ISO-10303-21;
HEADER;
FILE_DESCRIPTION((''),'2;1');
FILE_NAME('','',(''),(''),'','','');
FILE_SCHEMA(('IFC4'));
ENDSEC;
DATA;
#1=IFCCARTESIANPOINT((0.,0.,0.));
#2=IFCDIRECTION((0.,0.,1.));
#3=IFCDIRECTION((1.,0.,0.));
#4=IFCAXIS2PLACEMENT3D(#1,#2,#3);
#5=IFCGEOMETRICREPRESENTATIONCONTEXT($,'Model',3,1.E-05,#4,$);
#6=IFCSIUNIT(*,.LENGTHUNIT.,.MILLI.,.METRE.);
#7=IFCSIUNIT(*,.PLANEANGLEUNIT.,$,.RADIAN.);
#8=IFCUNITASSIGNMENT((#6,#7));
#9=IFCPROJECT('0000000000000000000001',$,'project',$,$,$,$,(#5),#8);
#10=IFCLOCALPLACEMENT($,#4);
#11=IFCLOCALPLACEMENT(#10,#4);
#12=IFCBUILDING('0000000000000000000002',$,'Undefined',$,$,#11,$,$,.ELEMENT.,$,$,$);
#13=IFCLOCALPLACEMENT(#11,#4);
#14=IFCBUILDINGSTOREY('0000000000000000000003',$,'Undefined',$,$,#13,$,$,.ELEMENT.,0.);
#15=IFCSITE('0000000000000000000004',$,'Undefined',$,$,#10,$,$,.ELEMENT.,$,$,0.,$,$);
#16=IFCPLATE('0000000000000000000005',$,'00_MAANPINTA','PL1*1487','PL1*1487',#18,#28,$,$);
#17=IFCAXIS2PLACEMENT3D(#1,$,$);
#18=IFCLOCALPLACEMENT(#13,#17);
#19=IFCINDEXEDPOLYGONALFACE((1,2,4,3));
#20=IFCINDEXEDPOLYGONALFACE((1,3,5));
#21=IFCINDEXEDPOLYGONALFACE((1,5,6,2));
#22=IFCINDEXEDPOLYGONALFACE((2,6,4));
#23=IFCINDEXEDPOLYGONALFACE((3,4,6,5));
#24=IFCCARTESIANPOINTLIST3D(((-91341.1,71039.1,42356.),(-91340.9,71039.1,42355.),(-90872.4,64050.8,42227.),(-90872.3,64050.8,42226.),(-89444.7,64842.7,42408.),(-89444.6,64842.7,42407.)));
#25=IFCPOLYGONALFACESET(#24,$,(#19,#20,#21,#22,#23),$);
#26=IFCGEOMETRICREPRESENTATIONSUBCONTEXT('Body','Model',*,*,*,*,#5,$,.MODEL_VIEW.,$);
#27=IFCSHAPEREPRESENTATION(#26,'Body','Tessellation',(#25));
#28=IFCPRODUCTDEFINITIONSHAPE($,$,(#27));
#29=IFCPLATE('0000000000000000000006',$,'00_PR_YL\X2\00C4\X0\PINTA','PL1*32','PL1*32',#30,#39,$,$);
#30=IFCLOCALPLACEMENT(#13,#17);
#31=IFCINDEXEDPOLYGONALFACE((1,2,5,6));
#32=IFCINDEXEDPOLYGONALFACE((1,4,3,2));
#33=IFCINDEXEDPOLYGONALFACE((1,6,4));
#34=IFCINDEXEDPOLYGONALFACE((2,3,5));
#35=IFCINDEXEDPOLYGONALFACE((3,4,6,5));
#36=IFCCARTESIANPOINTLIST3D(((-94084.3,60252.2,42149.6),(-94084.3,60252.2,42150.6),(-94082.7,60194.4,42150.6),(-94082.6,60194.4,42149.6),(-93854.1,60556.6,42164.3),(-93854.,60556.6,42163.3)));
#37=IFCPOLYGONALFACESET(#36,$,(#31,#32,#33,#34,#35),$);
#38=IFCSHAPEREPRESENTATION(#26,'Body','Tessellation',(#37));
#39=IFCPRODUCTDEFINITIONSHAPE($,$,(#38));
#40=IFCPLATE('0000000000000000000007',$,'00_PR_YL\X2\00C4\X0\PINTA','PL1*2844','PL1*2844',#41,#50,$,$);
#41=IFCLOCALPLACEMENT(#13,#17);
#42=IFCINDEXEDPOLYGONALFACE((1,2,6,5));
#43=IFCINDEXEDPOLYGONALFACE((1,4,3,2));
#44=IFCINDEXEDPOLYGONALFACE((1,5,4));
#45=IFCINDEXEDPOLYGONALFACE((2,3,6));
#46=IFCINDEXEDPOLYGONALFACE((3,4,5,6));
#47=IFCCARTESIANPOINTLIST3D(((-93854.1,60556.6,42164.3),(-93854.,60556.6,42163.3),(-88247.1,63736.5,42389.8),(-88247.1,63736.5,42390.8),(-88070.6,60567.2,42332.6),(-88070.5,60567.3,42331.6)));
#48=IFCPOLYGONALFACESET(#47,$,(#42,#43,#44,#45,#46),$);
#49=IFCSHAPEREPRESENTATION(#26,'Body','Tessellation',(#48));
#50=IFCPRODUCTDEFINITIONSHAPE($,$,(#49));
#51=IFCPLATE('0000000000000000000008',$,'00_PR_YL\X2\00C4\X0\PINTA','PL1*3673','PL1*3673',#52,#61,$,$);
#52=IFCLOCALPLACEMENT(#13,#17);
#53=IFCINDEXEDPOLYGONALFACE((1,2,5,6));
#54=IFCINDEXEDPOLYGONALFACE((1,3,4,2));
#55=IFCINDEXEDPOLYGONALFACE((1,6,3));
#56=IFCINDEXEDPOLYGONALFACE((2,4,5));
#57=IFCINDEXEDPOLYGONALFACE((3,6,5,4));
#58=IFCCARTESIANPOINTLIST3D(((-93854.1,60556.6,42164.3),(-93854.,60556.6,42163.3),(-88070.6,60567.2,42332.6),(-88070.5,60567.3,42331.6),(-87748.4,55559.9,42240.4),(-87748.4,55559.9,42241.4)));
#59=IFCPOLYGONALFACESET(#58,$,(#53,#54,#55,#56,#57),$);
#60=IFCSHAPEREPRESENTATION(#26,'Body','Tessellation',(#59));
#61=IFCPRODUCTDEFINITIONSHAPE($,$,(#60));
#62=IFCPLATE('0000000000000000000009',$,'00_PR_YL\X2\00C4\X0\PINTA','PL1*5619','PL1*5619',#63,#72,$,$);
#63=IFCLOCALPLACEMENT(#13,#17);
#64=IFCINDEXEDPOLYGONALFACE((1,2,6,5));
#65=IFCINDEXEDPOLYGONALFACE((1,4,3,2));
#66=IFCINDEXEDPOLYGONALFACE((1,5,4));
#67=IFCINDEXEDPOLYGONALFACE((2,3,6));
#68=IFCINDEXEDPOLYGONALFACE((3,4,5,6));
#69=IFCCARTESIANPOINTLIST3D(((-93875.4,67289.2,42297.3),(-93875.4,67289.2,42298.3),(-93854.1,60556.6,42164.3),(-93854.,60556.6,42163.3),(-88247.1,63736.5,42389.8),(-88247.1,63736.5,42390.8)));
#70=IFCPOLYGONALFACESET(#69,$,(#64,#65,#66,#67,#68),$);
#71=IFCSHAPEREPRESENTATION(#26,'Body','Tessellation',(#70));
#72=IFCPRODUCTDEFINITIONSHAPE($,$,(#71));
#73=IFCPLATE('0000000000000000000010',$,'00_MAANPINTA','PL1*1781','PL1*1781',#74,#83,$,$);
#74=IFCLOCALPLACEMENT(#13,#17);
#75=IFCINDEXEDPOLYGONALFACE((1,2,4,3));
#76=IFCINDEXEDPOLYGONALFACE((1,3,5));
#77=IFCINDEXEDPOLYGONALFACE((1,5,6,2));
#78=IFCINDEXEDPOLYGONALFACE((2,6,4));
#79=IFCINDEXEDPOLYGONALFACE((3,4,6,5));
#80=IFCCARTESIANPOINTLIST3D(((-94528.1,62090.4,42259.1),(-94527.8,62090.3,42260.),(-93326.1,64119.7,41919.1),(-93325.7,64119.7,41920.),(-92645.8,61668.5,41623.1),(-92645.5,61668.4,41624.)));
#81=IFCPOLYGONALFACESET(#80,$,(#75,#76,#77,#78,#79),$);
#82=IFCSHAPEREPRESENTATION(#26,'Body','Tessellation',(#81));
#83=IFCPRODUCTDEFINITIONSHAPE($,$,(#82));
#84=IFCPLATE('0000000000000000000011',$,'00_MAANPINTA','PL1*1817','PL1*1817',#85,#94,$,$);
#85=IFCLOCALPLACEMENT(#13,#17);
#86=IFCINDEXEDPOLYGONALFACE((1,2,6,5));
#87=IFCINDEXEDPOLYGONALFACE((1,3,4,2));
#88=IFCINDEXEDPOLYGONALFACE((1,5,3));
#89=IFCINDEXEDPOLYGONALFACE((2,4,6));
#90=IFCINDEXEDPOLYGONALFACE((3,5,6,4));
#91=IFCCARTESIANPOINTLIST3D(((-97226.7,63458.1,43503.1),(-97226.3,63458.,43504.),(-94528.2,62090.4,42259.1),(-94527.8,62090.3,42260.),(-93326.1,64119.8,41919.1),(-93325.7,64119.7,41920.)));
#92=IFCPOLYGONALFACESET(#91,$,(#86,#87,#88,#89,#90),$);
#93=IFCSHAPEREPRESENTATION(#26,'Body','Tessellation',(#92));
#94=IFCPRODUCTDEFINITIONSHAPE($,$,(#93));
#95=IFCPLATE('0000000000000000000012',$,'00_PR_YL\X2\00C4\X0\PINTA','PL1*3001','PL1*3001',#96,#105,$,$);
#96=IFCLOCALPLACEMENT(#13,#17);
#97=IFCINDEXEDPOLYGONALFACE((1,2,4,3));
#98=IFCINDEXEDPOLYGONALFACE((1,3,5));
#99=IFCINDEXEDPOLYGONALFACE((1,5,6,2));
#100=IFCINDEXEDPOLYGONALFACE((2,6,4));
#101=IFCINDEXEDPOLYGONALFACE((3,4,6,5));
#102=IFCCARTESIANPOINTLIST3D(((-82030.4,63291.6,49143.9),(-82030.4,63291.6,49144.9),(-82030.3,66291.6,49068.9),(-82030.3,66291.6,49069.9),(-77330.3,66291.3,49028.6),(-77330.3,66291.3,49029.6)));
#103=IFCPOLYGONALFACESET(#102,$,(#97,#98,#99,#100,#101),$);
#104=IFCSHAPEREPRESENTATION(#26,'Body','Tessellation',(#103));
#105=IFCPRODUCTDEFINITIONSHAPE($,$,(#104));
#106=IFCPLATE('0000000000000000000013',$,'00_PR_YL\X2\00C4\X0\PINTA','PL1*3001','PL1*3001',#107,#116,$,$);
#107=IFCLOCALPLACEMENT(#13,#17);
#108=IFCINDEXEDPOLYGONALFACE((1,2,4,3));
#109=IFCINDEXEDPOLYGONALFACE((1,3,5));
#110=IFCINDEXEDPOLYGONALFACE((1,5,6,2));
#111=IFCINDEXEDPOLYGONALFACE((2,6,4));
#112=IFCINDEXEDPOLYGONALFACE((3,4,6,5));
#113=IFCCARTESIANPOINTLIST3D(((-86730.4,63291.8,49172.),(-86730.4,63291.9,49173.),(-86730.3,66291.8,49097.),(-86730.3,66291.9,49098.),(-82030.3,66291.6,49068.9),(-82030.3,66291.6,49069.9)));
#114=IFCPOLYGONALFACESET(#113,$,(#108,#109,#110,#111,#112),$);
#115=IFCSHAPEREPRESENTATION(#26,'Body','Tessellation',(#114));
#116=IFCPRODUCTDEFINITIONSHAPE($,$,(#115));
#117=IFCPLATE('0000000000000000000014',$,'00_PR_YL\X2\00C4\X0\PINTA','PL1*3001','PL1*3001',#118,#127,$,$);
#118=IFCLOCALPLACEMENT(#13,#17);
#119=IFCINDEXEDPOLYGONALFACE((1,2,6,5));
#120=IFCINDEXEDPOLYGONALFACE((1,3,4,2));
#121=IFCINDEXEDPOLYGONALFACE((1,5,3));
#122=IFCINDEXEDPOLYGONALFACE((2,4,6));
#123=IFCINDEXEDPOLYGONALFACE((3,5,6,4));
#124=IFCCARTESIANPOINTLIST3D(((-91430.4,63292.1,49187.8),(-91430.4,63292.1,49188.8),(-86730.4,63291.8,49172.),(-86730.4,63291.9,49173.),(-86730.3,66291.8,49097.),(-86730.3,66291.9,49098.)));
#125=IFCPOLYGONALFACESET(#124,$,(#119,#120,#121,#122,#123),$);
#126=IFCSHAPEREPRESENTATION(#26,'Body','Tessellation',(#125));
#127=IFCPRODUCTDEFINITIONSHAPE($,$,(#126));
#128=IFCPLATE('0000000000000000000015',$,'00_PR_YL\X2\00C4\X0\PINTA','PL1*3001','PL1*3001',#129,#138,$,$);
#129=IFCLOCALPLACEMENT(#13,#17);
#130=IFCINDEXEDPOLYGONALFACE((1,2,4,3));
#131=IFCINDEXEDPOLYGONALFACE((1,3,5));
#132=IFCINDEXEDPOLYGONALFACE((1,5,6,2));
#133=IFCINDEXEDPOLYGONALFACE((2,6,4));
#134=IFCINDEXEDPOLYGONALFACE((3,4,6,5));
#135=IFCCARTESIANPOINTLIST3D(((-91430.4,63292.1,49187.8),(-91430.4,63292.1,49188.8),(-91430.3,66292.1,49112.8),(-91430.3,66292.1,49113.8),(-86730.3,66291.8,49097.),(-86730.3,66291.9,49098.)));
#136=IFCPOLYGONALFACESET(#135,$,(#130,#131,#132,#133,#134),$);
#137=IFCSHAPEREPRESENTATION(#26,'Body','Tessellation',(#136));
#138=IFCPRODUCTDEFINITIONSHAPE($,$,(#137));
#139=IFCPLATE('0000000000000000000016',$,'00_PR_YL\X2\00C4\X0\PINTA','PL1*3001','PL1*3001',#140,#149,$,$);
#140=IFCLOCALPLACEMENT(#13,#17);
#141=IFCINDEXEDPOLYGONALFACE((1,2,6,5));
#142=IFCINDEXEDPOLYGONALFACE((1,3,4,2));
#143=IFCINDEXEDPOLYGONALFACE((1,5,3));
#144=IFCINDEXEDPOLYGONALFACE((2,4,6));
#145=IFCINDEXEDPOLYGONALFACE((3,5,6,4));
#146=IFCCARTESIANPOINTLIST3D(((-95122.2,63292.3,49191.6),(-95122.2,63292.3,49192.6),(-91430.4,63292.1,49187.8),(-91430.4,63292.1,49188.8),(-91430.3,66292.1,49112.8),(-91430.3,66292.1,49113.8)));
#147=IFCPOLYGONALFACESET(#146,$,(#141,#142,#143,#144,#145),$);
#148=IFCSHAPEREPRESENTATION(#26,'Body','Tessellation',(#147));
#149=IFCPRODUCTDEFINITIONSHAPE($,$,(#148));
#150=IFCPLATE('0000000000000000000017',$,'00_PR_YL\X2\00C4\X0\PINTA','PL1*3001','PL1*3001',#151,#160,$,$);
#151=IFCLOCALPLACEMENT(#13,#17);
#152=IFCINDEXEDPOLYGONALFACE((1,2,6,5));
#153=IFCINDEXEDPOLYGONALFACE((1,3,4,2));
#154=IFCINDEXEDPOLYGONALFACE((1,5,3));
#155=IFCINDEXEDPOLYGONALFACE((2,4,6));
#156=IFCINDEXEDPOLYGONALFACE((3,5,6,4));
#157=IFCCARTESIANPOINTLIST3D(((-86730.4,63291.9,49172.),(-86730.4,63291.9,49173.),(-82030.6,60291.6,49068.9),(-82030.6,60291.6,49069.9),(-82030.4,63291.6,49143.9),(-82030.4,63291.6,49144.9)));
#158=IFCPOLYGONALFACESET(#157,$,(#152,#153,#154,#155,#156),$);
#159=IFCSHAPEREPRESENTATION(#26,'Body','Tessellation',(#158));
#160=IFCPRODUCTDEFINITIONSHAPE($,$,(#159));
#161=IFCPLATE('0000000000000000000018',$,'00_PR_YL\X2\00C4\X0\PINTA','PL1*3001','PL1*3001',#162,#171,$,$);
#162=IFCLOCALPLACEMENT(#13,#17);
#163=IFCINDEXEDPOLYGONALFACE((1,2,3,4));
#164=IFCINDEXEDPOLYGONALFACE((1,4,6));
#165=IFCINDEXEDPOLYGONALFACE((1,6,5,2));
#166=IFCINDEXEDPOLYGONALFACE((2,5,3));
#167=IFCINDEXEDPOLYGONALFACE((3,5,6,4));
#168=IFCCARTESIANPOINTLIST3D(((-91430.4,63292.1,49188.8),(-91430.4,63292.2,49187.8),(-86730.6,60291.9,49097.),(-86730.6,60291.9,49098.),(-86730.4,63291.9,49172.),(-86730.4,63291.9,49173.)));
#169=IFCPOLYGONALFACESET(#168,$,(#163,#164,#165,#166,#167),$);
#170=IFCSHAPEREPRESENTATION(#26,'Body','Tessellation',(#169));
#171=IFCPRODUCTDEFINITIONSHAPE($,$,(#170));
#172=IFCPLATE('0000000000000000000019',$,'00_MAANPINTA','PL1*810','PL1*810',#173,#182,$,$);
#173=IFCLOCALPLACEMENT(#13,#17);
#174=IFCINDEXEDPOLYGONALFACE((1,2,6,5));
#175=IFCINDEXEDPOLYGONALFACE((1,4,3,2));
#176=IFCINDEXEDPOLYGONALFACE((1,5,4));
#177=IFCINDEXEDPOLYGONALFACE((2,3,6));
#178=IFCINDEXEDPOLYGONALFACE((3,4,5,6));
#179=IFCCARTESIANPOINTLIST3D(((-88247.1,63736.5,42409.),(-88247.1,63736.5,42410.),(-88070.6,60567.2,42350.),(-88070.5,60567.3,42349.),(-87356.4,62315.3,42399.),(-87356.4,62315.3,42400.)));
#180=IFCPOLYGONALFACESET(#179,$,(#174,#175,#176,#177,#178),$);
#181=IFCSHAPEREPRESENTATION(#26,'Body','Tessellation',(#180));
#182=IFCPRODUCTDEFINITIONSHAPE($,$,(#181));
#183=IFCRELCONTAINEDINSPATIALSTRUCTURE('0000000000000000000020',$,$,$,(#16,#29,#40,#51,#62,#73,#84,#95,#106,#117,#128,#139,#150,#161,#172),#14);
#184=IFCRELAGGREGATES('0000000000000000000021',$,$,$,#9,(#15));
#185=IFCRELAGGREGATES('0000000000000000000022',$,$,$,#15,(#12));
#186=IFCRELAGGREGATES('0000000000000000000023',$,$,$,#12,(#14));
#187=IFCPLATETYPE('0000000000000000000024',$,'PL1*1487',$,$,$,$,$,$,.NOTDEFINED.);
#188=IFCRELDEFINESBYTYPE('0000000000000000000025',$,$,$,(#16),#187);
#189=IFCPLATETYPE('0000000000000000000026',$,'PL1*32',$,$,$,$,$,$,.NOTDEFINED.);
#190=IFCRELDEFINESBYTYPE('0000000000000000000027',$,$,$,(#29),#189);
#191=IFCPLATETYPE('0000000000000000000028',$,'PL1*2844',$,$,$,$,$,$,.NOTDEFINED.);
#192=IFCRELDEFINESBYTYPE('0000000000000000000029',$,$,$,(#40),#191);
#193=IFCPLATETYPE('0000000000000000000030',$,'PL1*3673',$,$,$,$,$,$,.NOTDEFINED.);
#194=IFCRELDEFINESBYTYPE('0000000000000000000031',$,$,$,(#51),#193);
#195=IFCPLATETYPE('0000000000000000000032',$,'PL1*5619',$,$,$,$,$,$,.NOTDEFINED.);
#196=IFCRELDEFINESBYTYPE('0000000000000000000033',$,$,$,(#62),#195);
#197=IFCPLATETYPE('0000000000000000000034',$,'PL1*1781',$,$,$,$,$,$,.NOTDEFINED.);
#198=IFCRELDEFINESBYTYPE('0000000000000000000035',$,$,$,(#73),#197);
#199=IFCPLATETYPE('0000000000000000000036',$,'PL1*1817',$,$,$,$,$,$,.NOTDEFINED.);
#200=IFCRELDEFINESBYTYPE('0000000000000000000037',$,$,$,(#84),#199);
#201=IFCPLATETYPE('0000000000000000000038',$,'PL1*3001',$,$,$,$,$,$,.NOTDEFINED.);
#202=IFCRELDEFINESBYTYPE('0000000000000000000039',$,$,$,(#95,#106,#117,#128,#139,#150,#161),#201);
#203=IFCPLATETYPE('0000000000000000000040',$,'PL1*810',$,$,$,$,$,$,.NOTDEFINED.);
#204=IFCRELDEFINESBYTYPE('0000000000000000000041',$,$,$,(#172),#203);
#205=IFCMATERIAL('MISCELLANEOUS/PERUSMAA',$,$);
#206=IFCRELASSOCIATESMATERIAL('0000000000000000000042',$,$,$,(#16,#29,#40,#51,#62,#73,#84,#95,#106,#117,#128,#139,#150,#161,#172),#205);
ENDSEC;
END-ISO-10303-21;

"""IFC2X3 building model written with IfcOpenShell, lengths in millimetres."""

from ifc_helpers import new_model, si_unit, frame, origin_with_axes, place, context, subcontext, project, spatial, polyline, outline, extrude, material, type_object, element, save


model = new_model("IFC2X3")

# Units and contexts
model_context = context("Model", 3, precision=1e-05, world=origin_with_axes())
body_context = subcontext(model_context, "Body", "Model", "MODEL_VIEW")
ifc_project = project(units=[si_unit("LENGTHUNIT", "METRE", prefix="MILLI"), si_unit("PLANEANGLEUNIT", "RADIAN")], contexts=[model_context])

# Site, building, storey
site_placement = place(None, origin_with_axes())
site = spatial("IfcSite", under=ifc_project, at=site_placement, Name="Undefined", CompositionType="ELEMENT", RefElevation=0.0)
building_placement = place(site_placement, origin_with_axes())
building = spatial("IfcBuilding", under=site, at=building_placement, Name="Undefined", CompositionType="ELEMENT")
storey_placement = place(building_placement, origin_with_axes())
storey = spatial("IfcBuildingStorey", under=building, at=storey_placement, Name="Undefined", CompositionType="ELEMENT", Elevation=0.0)

# Plates
ifc_material = material(Name="MISCELLANEOUS/PERUSMAA")
plate_type_1 = type_object("IfcPlateType", Name="PL1*1487", PredefinedType="NOTDEFINED")
plate_1_placement = place(storey_placement, frame((-89444.6, 64842.7, 42407.5), z_axis=(0.111618, 0.025824, -0.993416), x_axis=(-0.869161, -0.482098, -0.110189)))
element("IfcPlate", 1, at=plate_1_placement, inside=storey, type_object=plate_type_1, material=ifc_material, Name="00_MAANPINTA", Description="PL1*1487", ObjectType="PL1*1487", context=body_context, shape_type="SweptSolid", body=[
    extrude(outline(polyline([(0.0, 0.0), (1642.6, 0.0), (-1333.2, 6341.6), (0.0, 0.0)])), frame((0.0, 0.0, -0.5), z_axis=(0.0, 0.0, 1.0), x_axis=(1.0, 0.0, 0.0)), (0.0, 0.0, 1.0), 1.0),
])
plate_type_2 = type_object("IfcPlateType", Name="PL1*32", PredefinedType="NOTDEFINED")
plate_2_placement = place(storey_placement, frame((-93854.0, 60556.6, 42163.8), z_axis=(0.057025, 0.001812, -0.998371), x_axis=(-0.53355, -0.845163, -0.03201)))
element("IfcPlate", 2, at=plate_2_placement, inside=storey, type_object=plate_type_2, material=ifc_material, Name="00_PR_YLÄPINTA", Description="PL1*32", ObjectType="PL1*32", context=body_context, shape_type="SweptSolid", body=[
    extrude(outline(polyline([(0.0, 0.0), (428.5, 0.0), (380.5, 32.3), (0.0, 0.0)])), frame((0.0, 0.0, -0.5), z_axis=(0.0, 0.0, 1.0), x_axis=(1.0, 0.0, 0.0)), (0.0, 0.0, 1.0), 1.0),
])
plate_type_3 = type_object("IfcPlateType", Name="PL1*2844", PredefinedType="NOTDEFINED")
plate_3_placement = place(storey_placement, frame((-88247.1, 63736.5, 42390.3), z_axis=(0.029042, 0.019957, -0.999379), x_axis=(0.055609, -0.998285, -0.018319)))
element("IfcPlate", 3, at=plate_3_placement, inside=storey, type_object=plate_type_3, material=ifc_material, Name="00_PR_YLÄPINTA", Description="PL1*2844", ObjectType="PL1*2844", context=body_context, shape_type="SweptSolid", body=[
    extrude(outline(polyline([(0.0, 0.0), (3174.7, 0.0), (2866.8, 5777.7), (0.0, 0.0)])), frame((0.0, 0.0, -0.5), z_axis=(0.0, 0.0, 1.0), x_axis=(1.0, 0.0, 0.0)), (0.0, 0.0, 1.0), 1.0),
])
plate_type_4 = type_object("IfcPlateType", Name="PL1*3673", PredefinedType="NOTDEFINED")
plate_4_placement = place(storey_placement, frame((-88070.6, 60567.2, 42332.1), z_axis=(0.029042, 0.020064, -0.999377), x_axis=(0.0642, -0.997772, -0.018166)))
element("IfcPlate", 4, at=plate_4_placement, inside=storey, type_object=plate_type_4, material=ifc_material, Name="00_PR_YLÄPINTA", Description="PL1*3673", ObjectType="PL1*3673", context=body_context, shape_type="SweptSolid", body=[
    extrude(outline(polyline([(0.0, 0.0), (5018.5, 0.0), (-357.6, 5774.9), (0.0, 0.0)])), frame((0.0, 0.0, -0.5), z_axis=(0.0, 0.0, 1.0), x_axis=(1.0, 0.0, 0.0)), (0.0, 0.0, 1.0), 1.0),
])
plate_type_5 = type_object("IfcPlateType", Name="PL1*5619", PredefinedType="NOTDEFINED")
plate_5_placement = place(storey_placement, frame((-93854.0, 60556.6, 42163.8), z_axis=(0.029031, 0.019976, -0.999379), x_axis=(-0.003169, 0.999797, 0.019892)))
element("IfcPlate", 5, at=plate_5_placement, inside=storey, type_object=plate_type_5, material=ifc_material, Name="00_PR_YLÄPINTA", Description="PL1*5619", ObjectType="PL1*5619", context=body_context, shape_type="SweptSolid", body=[
    extrude(outline(polyline([(0.0, 0.0), (6733.9, 0.0), (3166.0, 5619.4), (0.0, 0.0)])), frame((0.0, 0.0, -0.5), z_axis=(0.0, 0.0, 1.0), x_axis=(1.0, 0.0, 0.0)), (0.0, 0.0, 1.0), 1.0),
])
plate_type_6 = type_object("IfcPlateType", Name="PL1*1781", PredefinedType="NOTDEFINED")
plate_6_placement = place(storey_placement, frame((-92645.7, 61668.4, 41623.5), z_axis=(-0.314481, 0.027309, -0.948871), x_axis=(-0.92672, 0.20772, 0.313118)))
element("IfcPlate", 6, at=plate_6_placement, inside=storey, type_object=plate_type_6, material=ifc_material, Name="00_MAANPINTA", Description="PL1*1781", ObjectType="PL1*1781", context=body_context, shape_type="SweptSolid", body=[
    extrude(outline(polyline([(0.0, 0.0), (2031.2, 0.0), (1232.3, 2245.1), (0.0, 0.0)])), frame((0.0, 0.0, -0.5), z_axis=(0.0, 0.0, 1.0), x_axis=(1.0, 0.0, 0.0)), (0.0, 0.0, 1.0), 1.0),
])
plate_type_7 = type_object("IfcPlateType", Name="PL1*1817", PredefinedType="NOTDEFINED")
plate_7_placement = place(storey_placement, frame((-93325.9, 64119.7, 41919.5), z_axis=(-0.386048, 0.074631, -0.919455), x_axis=(-0.504437, -0.851579, 0.142675)))
element("IfcPlate", 7, at=plate_7_placement, inside=storey, type_object=plate_type_7, material=ifc_material, Name="00_MAANPINTA", Description="PL1*1817", ObjectType="PL1*1817", context=body_context, shape_type="SweptSolid", body=[
    extrude(outline(polyline([(0.0, 0.0), (2383.0, 0.0), (2757.0, 3249.6), (0.0, 0.0)])), frame((0.0, 0.0, -0.5), z_axis=(0.0, 0.0, 1.0), x_axis=(1.0, 0.0, 0.0)), (0.0, 0.0, 1.0), 1.0),
])
plate_type_8 = type_object("IfcPlateType", Name="PL1*3001", PredefinedType="NOTDEFINED")
plate_8_placement = place(storey_placement, frame((-82030.4, 63291.6, 49144.4), z_axis=(-0.008578, -0.024991, -0.999651), x_axis=(0.000057, 0.999688, -0.024992)))
element("IfcPlate", 8, at=plate_8_placement, inside=storey, type_object=plate_type_8, material=ifc_material, Name="00_PR_YLÄPINTA", Description="PL1*3001", ObjectType="PL1*3001", context=body_context, shape_type="SweptSolid", body=[
    extrude(outline(polyline([(0.0, 0.0), (3000.9, 0.0), (3001.9, 4700.2), (0.0, 0.0)])), frame((0.0, 0.0, -0.5), z_axis=(0.0, 0.0, 1.0), x_axis=(1.0, 0.0, 0.0)), (0.0, 0.0, 1.0), 1.0),
])
plate_9_placement = place(storey_placement, frame((-86730.4, 63291.8, 49172.5), z_axis=(-0.005967, -0.024991, -0.99967), x_axis=(0.000057, 0.999688, -0.024992)))
element("IfcPlate", 9, at=plate_9_placement, inside=storey, type_object=plate_type_8, material=ifc_material, Name="00_PR_YLÄPINTA", Description="PL1*3001", ObjectType="PL1*3001", context=body_context, shape_type="SweptSolid", body=[
    extrude(outline(polyline([(0.0, 0.0), (3000.9, 0.0), (3001.6, 4700.1), (0.0, 0.0)])), frame((0.0, 0.0, -0.5), z_axis=(0.0, 0.0, 1.0), x_axis=(1.0, 0.0, 0.0)), (0.0, 0.0, 1.0), 1.0),
])
for number, where, z_axis, x_axis, name in (
    (10, (-86730.3, 66291.8, 49097.5), (-0.003357, -0.024992, -0.999682), (-0.000057, -0.999688, 0.024992), "00_PR_YLÄPINTA"),
    (11, (-91430.4, 63292.1, 49188.3), (-0.003357, -0.024992, -0.999682), (0.000057, 0.999688, -0.024992), "00_PR_YLÄPINTA"),
):
    element("IfcPlate", number, at=place(storey_placement, frame(where, z_axis=z_axis, x_axis=x_axis)), inside=storey, type_object=plate_type_8, material=ifc_material, Name=name, Description="PL1*3001", ObjectType="PL1*3001", context=body_context, shape_type="SweptSolid", body=[
        extrude(outline(polyline([(0.0, 0.0), (3000.9, 0.0), (3001.3, 4700.0), (0.0, 0.0)])), frame((0.0, 0.0, -0.5), z_axis=(0.0, 0.0, 1.0), x_axis=(1.0, 0.0, 0.0)), (0.0, 0.0, 1.0), 1.0),
    ])
plate_10_placement = place(storey_placement, frame((-91430.3, 66292.1, 49113.3), z_axis=(-0.001026, -0.024992, -0.999687), x_axis=(-0.000057, -0.999688, 0.024992)))
element("IfcPlate", 12, at=plate_10_placement, inside=storey, type_object=plate_type_8, material=ifc_material, Name="00_PR_YLÄPINTA", Description="PL1*3001", ObjectType="PL1*3001", context=body_context, shape_type="SweptSolid", body=[
    extrude(outline(polyline([(0.0, 0.0), (3000.9, 0.0), (3001.0, 3691.7), (0.0, 0.0)])), frame((0.0, 0.0, -0.5), z_axis=(0.0, 0.0, 1.0), x_axis=(1.0, 0.0, 0.0)), (0.0, 0.0, 1.0), 1.0),
])
plate_11_placement = place(storey_placement, frame((-86730.4, 63291.9, 49172.5), z_axis=(-0.005964, 0.024992, -0.99967), x_axis=(0.999982, -0.000057, -0.005968)))
element("IfcPlate", 13, at=plate_11_placement, inside=storey, type_object=plate_type_8, material=ifc_material, Name="00_PR_YLÄPINTA", Description="PL1*3001", ObjectType="PL1*3001", context=body_context, shape_type="SweptSolid", body=[
    extrude(outline(polyline([(0.0, 0.0), (4700.1, 0.0), (4700.5, 3000.9), (0.0, 0.0)])), frame((0.0, 0.0, -0.5), z_axis=(0.0, 0.0, 1.0), x_axis=(1.0, 0.0, 0.0)), (0.0, 0.0, 1.0), 1.0),
])
plate_12_placement = place(storey_placement, frame((-91430.4, 63292.1, 49188.3), z_axis=(-0.003354, 0.024992, -0.999682), x_axis=(0.999994, -0.000057, -0.003357)))
element("IfcPlate", 14, at=plate_12_placement, inside=storey, type_object=plate_type_8, material=ifc_material, Name="00_PR_YLÄPINTA", Description="PL1*3001", ObjectType="PL1*3001", context=body_context, shape_type="SweptSolid", body=[
    extrude(outline(polyline([(0.0, 0.0), (4700.0, 0.0), (4700.3, 3000.9), (0.0, 0.0)])), frame((0.0, 0.0, -0.5), z_axis=(0.0, 0.0, 1.0), x_axis=(1.0, 0.0, 0.0)), (0.0, 0.0, 1.0), 1.0),
])
plate_type_9 = type_object("IfcPlateType", Name="PL1*810", PredefinedType="NOTDEFINED")
plate_13_placement = place(storey_placement, frame((-88247.1, 63736.5, 42409.5), z_axis=(0.020823, 0.020084, -0.999581), x_axis=(0.531045, -0.847323, -0.005962)))
element("IfcPlate", 15, at=plate_13_placement, inside=storey, type_object=plate_type_9, material=ifc_material, Name="00_MAANPINTA", Description="PL1*810", ObjectType="PL1*810", context=body_context, shape_type="SweptSolid", body=[
    extrude(outline(polyline([(0.0, 0.0), (1677.3, 0.0), (2779.5, 1534.1), (0.0, 0.0)])), frame((0.0, 0.0, -0.5), z_axis=(0.0, 0.0, 1.0), x_axis=(1.0, 0.0, 0.0)), (0.0, 0.0, 1.0), 1.0),
])

save(model, "model.ifc")
